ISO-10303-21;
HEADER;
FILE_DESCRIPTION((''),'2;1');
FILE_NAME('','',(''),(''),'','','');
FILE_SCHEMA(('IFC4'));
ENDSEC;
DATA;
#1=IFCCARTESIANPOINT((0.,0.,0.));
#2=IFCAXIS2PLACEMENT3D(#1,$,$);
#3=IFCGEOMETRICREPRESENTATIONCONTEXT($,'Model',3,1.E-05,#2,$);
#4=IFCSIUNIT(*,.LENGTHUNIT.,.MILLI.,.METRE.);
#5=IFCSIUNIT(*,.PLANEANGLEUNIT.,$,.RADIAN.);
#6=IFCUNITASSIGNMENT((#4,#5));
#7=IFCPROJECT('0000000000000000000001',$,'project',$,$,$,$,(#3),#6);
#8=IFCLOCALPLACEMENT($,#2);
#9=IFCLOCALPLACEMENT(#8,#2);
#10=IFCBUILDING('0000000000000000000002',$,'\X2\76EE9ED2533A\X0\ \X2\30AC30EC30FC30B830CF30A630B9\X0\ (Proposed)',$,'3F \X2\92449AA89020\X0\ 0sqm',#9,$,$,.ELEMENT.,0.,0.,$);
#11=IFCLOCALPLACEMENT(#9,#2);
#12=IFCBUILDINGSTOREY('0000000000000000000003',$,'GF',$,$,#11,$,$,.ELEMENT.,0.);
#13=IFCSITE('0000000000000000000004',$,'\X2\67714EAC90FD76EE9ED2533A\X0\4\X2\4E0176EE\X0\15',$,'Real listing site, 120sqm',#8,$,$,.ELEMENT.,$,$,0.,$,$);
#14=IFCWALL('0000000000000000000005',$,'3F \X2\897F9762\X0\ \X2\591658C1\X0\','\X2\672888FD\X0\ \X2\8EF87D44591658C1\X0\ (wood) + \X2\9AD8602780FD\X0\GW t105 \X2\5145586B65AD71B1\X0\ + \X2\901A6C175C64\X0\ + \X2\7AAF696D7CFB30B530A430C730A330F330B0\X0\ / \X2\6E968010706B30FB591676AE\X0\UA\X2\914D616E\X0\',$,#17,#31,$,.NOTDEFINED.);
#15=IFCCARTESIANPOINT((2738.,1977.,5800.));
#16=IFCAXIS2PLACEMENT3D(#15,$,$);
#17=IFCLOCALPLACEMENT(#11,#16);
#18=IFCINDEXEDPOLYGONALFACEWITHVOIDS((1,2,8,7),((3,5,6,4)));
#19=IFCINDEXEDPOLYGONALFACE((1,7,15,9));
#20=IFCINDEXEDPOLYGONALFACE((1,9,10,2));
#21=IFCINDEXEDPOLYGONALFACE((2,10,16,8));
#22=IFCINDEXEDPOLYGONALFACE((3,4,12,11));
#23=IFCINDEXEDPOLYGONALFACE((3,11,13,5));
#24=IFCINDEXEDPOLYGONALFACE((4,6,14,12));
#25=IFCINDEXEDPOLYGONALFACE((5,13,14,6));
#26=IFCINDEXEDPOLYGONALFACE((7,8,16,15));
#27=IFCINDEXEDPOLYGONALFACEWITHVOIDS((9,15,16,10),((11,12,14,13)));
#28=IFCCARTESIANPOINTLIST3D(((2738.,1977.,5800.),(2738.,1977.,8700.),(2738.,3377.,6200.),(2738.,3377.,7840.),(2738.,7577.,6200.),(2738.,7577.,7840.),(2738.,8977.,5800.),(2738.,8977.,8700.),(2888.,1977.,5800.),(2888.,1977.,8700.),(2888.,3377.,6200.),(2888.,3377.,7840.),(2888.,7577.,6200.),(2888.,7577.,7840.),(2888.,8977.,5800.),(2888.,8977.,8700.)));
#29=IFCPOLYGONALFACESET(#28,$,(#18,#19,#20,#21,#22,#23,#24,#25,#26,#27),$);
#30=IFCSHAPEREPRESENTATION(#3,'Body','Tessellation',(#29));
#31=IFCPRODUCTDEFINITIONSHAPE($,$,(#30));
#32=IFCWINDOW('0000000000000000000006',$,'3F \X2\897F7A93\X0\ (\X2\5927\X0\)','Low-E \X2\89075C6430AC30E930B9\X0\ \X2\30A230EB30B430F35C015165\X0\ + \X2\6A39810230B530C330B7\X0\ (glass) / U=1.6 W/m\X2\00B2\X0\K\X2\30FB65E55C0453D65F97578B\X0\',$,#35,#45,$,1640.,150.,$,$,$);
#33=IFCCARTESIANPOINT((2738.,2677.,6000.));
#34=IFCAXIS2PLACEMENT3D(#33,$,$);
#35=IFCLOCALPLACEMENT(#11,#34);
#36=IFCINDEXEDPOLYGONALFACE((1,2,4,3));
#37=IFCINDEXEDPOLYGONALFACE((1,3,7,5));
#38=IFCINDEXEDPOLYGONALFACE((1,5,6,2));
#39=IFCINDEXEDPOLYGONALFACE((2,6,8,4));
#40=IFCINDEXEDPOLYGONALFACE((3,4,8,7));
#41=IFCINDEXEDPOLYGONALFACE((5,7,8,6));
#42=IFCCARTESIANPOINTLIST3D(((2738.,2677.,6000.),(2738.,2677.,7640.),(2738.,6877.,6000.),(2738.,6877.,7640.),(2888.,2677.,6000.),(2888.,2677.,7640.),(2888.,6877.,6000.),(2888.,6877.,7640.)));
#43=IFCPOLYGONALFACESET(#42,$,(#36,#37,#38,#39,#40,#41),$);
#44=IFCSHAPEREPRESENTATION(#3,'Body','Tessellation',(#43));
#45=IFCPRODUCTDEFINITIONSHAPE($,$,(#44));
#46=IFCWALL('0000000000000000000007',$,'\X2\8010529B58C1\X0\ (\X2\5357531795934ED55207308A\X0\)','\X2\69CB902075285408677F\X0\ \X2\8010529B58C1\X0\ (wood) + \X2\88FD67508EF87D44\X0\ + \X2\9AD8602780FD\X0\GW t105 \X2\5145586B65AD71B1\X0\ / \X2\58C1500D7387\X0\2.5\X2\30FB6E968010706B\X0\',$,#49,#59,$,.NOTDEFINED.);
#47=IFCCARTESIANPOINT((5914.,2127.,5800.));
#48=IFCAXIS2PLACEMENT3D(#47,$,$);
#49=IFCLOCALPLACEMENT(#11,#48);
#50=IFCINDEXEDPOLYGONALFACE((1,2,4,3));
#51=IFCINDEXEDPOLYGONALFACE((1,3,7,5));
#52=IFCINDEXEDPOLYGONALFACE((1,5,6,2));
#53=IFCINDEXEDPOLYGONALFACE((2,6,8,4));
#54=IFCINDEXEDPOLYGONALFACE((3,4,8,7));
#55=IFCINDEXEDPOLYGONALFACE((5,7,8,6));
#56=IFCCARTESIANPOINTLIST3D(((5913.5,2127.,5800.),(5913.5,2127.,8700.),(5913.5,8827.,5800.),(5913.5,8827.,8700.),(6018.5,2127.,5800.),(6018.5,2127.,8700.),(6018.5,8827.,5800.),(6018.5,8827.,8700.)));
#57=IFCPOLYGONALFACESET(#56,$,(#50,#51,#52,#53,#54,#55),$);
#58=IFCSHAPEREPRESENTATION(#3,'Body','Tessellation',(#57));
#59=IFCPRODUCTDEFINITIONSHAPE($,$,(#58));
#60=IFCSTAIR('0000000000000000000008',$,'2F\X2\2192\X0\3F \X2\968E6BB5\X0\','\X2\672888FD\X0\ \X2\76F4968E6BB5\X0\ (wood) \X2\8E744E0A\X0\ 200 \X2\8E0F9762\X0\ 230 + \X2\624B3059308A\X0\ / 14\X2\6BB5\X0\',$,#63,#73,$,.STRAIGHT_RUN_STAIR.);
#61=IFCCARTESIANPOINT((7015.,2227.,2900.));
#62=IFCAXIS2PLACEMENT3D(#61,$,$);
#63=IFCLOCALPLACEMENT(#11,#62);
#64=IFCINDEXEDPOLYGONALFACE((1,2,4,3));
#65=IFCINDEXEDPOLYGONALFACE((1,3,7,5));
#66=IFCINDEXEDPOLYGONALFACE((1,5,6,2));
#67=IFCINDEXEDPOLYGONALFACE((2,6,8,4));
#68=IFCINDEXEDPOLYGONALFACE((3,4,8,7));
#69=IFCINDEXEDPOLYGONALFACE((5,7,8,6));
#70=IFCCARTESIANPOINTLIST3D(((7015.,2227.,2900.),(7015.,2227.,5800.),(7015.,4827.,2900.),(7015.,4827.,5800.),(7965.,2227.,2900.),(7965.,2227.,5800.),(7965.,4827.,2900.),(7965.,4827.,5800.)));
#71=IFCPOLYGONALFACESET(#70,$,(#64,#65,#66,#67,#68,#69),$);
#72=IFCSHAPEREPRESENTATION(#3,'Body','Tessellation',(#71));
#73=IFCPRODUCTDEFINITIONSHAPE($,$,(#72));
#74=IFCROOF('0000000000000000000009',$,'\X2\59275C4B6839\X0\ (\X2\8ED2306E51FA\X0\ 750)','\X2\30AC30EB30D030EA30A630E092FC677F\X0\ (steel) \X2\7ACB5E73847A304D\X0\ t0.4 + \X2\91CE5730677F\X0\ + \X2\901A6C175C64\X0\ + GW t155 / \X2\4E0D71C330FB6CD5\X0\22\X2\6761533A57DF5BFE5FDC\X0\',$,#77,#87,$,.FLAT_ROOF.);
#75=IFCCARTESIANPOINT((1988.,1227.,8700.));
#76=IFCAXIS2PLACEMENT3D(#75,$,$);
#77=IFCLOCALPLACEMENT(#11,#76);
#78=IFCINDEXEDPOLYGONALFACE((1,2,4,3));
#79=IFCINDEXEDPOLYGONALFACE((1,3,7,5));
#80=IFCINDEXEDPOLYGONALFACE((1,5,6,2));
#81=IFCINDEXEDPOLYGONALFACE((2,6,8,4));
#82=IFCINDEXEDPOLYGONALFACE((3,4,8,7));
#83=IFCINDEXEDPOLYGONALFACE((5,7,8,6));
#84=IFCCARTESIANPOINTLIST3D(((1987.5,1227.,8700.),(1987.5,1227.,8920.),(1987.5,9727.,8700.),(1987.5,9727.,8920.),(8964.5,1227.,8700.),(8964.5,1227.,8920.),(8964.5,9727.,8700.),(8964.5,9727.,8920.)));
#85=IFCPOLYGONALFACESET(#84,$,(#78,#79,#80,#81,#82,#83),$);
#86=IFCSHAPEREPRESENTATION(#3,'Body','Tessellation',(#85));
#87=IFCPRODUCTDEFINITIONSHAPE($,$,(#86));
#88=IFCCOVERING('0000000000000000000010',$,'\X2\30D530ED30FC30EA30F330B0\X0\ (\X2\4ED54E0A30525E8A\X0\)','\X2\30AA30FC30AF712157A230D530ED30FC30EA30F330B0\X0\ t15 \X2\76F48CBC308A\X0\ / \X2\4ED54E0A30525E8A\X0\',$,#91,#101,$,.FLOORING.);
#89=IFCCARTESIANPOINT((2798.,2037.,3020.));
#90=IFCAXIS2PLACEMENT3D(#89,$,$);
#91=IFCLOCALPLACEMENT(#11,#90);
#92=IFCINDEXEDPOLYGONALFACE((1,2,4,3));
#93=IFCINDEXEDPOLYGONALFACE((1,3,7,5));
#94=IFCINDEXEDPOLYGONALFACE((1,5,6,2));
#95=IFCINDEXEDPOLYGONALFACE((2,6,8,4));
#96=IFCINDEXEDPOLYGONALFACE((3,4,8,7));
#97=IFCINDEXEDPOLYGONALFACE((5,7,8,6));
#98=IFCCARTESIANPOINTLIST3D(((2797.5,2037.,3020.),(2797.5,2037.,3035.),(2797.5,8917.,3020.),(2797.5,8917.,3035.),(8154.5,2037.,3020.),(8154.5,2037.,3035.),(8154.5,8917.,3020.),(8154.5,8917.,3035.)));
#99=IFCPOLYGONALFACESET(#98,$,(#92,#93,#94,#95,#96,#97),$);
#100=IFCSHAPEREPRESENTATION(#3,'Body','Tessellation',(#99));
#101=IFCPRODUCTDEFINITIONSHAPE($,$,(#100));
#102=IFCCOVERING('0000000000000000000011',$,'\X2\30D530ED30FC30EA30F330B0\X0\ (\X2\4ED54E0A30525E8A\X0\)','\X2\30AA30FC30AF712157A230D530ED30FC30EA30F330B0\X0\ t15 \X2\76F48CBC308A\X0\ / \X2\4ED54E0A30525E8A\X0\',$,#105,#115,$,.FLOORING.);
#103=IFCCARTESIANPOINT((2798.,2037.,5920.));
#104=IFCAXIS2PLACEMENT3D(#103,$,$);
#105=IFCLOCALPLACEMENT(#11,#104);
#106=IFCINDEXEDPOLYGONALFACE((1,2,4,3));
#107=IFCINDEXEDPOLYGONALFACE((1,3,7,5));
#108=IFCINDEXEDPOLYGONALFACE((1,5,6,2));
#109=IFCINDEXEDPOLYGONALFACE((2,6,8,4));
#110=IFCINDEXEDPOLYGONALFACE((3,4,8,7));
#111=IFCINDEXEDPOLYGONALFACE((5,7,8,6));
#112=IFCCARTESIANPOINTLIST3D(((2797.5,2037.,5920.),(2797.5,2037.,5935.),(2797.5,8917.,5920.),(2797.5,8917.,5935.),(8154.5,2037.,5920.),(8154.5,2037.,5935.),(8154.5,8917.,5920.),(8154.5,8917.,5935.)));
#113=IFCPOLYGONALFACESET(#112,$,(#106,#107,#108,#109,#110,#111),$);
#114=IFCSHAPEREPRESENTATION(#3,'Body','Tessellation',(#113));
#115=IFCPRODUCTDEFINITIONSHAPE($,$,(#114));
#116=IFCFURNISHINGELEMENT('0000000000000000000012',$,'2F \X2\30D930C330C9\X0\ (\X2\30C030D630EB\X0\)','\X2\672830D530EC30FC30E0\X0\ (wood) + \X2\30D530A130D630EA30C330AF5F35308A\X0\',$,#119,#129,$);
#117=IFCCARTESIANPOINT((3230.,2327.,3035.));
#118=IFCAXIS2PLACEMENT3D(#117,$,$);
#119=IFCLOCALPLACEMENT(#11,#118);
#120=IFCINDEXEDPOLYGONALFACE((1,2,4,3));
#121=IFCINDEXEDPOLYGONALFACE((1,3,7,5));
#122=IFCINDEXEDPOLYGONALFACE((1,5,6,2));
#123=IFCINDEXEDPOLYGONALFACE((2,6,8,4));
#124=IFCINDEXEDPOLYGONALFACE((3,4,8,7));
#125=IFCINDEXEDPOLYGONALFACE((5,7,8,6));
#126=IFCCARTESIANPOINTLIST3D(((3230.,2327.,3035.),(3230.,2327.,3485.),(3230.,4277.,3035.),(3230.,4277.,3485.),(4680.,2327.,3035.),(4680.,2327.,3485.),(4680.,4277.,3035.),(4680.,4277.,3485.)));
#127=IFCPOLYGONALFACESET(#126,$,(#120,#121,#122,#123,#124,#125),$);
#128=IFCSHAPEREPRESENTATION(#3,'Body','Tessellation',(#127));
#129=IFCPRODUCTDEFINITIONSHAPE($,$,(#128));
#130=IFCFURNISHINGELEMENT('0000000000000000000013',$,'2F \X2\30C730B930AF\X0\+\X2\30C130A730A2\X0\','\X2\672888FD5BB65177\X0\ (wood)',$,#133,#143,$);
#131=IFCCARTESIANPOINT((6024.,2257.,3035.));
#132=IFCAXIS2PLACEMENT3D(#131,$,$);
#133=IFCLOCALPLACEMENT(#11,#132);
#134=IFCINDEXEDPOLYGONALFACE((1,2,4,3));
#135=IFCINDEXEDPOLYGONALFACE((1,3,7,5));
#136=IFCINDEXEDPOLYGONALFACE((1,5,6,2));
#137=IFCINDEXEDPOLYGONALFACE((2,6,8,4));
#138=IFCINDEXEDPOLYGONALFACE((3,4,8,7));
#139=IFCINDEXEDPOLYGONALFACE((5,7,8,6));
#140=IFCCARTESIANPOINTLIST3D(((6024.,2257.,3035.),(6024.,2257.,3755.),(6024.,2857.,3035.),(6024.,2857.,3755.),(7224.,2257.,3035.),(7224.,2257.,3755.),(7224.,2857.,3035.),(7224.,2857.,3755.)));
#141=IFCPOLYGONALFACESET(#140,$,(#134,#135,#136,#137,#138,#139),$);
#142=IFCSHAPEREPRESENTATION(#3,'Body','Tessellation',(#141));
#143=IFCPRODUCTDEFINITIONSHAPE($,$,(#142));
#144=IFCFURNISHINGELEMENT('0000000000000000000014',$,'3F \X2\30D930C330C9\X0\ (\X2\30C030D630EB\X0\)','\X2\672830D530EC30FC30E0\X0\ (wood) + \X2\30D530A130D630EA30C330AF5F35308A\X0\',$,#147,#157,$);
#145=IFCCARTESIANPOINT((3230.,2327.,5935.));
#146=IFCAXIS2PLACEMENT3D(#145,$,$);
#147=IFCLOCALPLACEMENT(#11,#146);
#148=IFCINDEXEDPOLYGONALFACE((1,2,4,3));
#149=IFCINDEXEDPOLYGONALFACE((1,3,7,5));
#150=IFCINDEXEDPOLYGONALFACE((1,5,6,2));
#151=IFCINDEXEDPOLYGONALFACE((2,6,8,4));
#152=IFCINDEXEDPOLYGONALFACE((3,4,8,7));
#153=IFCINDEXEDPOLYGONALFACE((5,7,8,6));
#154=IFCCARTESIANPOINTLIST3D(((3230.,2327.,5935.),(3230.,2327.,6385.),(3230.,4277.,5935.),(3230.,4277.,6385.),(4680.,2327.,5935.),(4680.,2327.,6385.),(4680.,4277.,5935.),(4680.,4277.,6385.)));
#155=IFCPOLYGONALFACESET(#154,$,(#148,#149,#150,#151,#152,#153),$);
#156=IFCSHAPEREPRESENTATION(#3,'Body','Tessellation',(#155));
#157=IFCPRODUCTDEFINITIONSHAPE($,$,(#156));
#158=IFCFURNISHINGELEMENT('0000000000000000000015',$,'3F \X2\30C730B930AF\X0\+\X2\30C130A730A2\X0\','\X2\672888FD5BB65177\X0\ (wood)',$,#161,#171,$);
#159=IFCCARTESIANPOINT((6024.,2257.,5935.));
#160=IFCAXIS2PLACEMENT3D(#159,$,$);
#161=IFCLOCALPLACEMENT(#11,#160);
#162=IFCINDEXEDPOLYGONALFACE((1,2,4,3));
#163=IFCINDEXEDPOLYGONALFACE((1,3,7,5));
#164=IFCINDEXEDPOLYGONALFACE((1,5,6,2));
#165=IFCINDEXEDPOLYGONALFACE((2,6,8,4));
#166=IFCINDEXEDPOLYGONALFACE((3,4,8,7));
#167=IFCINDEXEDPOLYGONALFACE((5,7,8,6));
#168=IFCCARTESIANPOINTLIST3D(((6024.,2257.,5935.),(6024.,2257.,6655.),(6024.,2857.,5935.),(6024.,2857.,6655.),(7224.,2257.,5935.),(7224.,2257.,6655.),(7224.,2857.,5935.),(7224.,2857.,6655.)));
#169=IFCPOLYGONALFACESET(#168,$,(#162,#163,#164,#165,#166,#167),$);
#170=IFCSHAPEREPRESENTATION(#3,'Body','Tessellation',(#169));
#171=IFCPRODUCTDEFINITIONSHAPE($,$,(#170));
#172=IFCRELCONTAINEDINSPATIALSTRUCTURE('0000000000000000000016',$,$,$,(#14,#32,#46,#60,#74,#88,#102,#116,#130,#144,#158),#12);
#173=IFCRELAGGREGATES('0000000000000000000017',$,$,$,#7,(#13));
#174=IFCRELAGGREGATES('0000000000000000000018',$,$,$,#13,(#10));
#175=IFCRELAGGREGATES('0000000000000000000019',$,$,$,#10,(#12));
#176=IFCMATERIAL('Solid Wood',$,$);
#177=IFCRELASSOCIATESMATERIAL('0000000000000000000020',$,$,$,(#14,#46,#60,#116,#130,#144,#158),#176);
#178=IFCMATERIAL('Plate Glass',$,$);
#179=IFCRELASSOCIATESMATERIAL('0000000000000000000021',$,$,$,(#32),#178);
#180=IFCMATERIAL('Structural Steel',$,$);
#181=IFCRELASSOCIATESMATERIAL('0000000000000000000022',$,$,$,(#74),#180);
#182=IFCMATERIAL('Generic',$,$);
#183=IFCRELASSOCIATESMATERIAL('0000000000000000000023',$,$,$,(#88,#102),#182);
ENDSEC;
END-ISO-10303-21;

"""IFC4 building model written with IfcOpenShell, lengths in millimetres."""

from ifc_helpers import new_model, si_unit, frame, frame_2d, origin, place, context, project, spatial, rectangle, extrude, material, element, fill, save


model = new_model("IFC4")

# Units and contexts
model_context = context("Model", 3, precision=1e-05, world=origin())
ifc_project = project(units=[si_unit("LENGTHUNIT", "METRE", prefix="MILLI"), si_unit("PLANEANGLEUNIT", "RADIAN")], contexts=[model_context])

# Site, building, storey
site_placement = place(None, origin())
site = spatial("IfcSite", under=ifc_project, at=site_placement, Name="東京都目黒区4丁目15", ObjectType="Real listing site, 120sqm", CompositionType="ELEMENT", RefElevation=0.0)
building_placement = place(site_placement, origin())
building = spatial("IfcBuilding", under=site, at=building_placement, Name="目黒区 ガレージハウス (Proposed)", ObjectType="3F 鉄骨造 0sqm", CompositionType="ELEMENT", ElevationOfRefHeight=0.0, ElevationOfTerrain=0.0)
storey_placement = place(building_placement, origin())
storey = spatial("IfcBuildingStorey", under=building, at=storey_placement, Name="GF", CompositionType="ELEMENT", Elevation=0.0)

# Shared definitions
ifc_material_1 = material(Name="Solid Wood")

# Shared definitions
ifc_material_2 = material(Name="Plate Glass")

# Wall, opening, window
wall_1_placement = place(storey_placement, frame((2738.0, 1977.0, 5800.0)))
wall_1 = element("IfcWall", 1, at=wall_1_placement, inside=storey, material=ifc_material_1, Name="3F 西面 外壁", Description="木製 軸組外壁 (wood) + 高性能GW t105 充填断熱 + 通気層 + 窯業系サイディング / 準耐火・外皮UA配慮", PredefinedType="NOTDEFINED", context=model_context, shape_type="SweptSolid", body=[
    extrude(rectangle(XDim=150.0, YDim=7000.0, at=frame_2d((75.0, 3500.0))), frame((2738.0, 1977.0, 5800.0)), (0.0, 0.0, 1.0), 2900.0),
])
opening_1_placement = place(storey_placement, frame((2738.0, 2677.0, 6000.0)))
opening_1 = element("IfcOpeningElement", 2, at=opening_1_placement, cuts=wall_1, PredefinedType="NOTDEFINED", context=model_context, shape_type="SweptSolid", body=[
    extrude(rectangle(XDim=150.0, YDim=4200.0, at=frame_2d((75.0, 2100.0))), frame((2738.0, 2677.0, 6000.0)), (0.0, 0.0, 1.0), 1640.0),
])
window_1_placement = place(storey_placement, frame((2738.0, 2677.0, 6000.0)))
window_1 = element("IfcWindow", 3, at=window_1_placement, inside=storey, material=ifc_material_2, Name="3F 西窓 (大)", Description="Low-E 複層ガラス アルゴン封入 + 樹脂サッシ (glass) / U=1.6 W/m²K・日射取得型", OverallHeight=1640.0, OverallWidth=150.0, context=model_context, shape_type="SweptSolid", body=[
    extrude(rectangle(XDim=150.0, YDim=4200.0, at=frame_2d((75.0, 2100.0))), frame((2738.0, 2677.0, 6000.0)), (0.0, 0.0, 1.0), 1640.0),
])
fill(opening_1, window_1)

# Wall
wall_2_placement = place(storey_placement, frame((5914.0, 2127.0, 5800.0)))
element("IfcWall", 4, at=wall_2_placement, inside=storey, material=ifc_material_1, Name="耐力壁 (南北間仕切り)", Description="構造用合板 耐力壁 (wood) + 製材軸組 + 高性能GW t105 充填断熱 / 壁倍率2.5・準耐火", PredefinedType="NOTDEFINED", context=model_context, shape_type="SweptSolid", body=[
    extrude(rectangle(XDim=105.0, YDim=6700.0, at=frame_2d((52.0, 3350.0))), frame((5914.0, 2127.0, 5800.0)), (0.0, 0.0, 1.0), 2900.0),
])

# Stair
stair_placement = place(storey_placement, frame((7015.0, 2227.0, 2900.0)))
element("IfcStair", 5, at=stair_placement, inside=storey, material=ifc_material_1, Name="2F→3F 階段", Description="木製 直階段 (wood) 蹴上 200 踏面 230 + 手すり / 14段", PredefinedType="STRAIGHT_RUN_STAIR", context=model_context, shape_type="SweptSolid", body=[
    extrude(rectangle(XDim=950.0, YDim=2600.0, at=frame_2d((475.0, 1300.0))), frame((7015.0, 2227.0, 2900.0)), (0.0, 0.0, 1.0), 2900.0),
])

# Roof
ifc_material_3 = material(Name="Structural Steel")
roof_placement = place(storey_placement, frame((1988.0, 1227.0, 8700.0)))
element("IfcRoof", 6, at=roof_placement, inside=storey, material=ifc_material_3, Name="大屋根 (軒の出 750)", Description="ガルバリウム鋼板 (steel) 立平葺き t0.4 + 野地板 + 通気層 + GW t155 / 不燃・法22条区域対応", PredefinedType="FLAT_ROOF", context=model_context, shape_type="SweptSolid", body=[
    extrude(rectangle(XDim=6977.0, YDim=8500.0, at=frame_2d((3488.0, 4250.0))), frame((1988.0, 1227.0, 8700.0)), (0.0, 0.0, 1.0), 220.0),
])

# Coverings
ifc_material_4 = material(Name="Generic")
covering_1_placement = place(storey_placement, frame((2798.0, 2037.0, 3020.0)))
element("IfcCovering", 7, at=covering_1_placement, inside=storey, material=ifc_material_4, Name="フローリング (仕上げ床)", Description="オーク無垢フローリング t15 直貼り / 仕上げ床", PredefinedType="FLOORING", context=model_context, shape_type="SweptSolid", body=[
    extrude(rectangle(XDim=5357.0, YDim=6880.0, at=frame_2d((2678.0, 3440.0))), frame((2798.0, 2037.0, 3020.0)), (0.0, 0.0, 1.0), 15.0),
])
covering_2_placement = place(storey_placement, frame((2798.0, 2037.0, 5920.0)))
element("IfcCovering", 8, at=covering_2_placement, inside=storey, material=ifc_material_4, Name="フローリング (仕上げ床)", Description="オーク無垢フローリング t15 直貼り / 仕上げ床", PredefinedType="FLOORING", context=model_context, shape_type="SweptSolid", body=[
    extrude(rectangle(XDim=5357.0, YDim=6880.0, at=frame_2d((2678.0, 3440.0))), frame((2798.0, 2037.0, 5920.0)), (0.0, 0.0, 1.0), 15.0),
])

# Furnishing elements
furnishing_1_placement = place(storey_placement, frame((3230.0, 2327.0, 3035.0)))
element("IfcFurnishingElement", 9, at=furnishing_1_placement, inside=storey, material=ifc_material_1, Name="2F ベッド (ダブル)", Description="木フレーム (wood) + ファブリック張り", context=model_context, shape_type="SweptSolid", body=[
    extrude(rectangle(XDim=1450.0, YDim=1950.0, at=frame_2d((725.0, 975.0))), frame((3230.0, 2327.0, 3035.0)), (0.0, 0.0, 1.0), 450.0),
])
furnishing_2_placement = place(storey_placement, frame((6024.0, 2257.0, 3035.0)))
element("IfcFurnishingElement", 10, at=furnishing_2_placement, inside=storey, material=ifc_material_1, Name="2F デスク+チェア", Description="木製家具 (wood)", context=model_context, shape_type="SweptSolid", body=[
    extrude(rectangle(XDim=1200.0, YDim=600.0, at=frame_2d((600.0, 300.0))), frame((6024.0, 2257.0, 3035.0)), (0.0, 0.0, 1.0), 720.0),
])
furnishing_3_placement = place(storey_placement, frame((3230.0, 2327.0, 5935.0)))
element("IfcFurnishingElement", 11, at=furnishing_3_placement, inside=storey, material=ifc_material_1, Name="3F ベッド (ダブル)", Description="木フレーム (wood) + ファブリック張り", context=model_context, shape_type="SweptSolid", body=[
    extrude(rectangle(XDim=1450.0, YDim=1950.0, at=frame_2d((725.0, 975.0))), frame((3230.0, 2327.0, 5935.0)), (0.0, 0.0, 1.0), 450.0),
])
furnishing_4_placement = place(storey_placement, frame((6024.0, 2257.0, 5935.0)))
element("IfcFurnishingElement", 12, at=furnishing_4_placement, inside=storey, material=ifc_material_1, Name="3F デスク+チェア", Description="木製家具 (wood)", context=model_context, shape_type="SweptSolid", body=[
    extrude(rectangle(XDim=1200.0, YDim=600.0, at=frame_2d((600.0, 300.0))), frame((6024.0, 2257.0, 5935.0)), (0.0, 0.0, 1.0), 720.0),
])

save(model, "model.ifc")
